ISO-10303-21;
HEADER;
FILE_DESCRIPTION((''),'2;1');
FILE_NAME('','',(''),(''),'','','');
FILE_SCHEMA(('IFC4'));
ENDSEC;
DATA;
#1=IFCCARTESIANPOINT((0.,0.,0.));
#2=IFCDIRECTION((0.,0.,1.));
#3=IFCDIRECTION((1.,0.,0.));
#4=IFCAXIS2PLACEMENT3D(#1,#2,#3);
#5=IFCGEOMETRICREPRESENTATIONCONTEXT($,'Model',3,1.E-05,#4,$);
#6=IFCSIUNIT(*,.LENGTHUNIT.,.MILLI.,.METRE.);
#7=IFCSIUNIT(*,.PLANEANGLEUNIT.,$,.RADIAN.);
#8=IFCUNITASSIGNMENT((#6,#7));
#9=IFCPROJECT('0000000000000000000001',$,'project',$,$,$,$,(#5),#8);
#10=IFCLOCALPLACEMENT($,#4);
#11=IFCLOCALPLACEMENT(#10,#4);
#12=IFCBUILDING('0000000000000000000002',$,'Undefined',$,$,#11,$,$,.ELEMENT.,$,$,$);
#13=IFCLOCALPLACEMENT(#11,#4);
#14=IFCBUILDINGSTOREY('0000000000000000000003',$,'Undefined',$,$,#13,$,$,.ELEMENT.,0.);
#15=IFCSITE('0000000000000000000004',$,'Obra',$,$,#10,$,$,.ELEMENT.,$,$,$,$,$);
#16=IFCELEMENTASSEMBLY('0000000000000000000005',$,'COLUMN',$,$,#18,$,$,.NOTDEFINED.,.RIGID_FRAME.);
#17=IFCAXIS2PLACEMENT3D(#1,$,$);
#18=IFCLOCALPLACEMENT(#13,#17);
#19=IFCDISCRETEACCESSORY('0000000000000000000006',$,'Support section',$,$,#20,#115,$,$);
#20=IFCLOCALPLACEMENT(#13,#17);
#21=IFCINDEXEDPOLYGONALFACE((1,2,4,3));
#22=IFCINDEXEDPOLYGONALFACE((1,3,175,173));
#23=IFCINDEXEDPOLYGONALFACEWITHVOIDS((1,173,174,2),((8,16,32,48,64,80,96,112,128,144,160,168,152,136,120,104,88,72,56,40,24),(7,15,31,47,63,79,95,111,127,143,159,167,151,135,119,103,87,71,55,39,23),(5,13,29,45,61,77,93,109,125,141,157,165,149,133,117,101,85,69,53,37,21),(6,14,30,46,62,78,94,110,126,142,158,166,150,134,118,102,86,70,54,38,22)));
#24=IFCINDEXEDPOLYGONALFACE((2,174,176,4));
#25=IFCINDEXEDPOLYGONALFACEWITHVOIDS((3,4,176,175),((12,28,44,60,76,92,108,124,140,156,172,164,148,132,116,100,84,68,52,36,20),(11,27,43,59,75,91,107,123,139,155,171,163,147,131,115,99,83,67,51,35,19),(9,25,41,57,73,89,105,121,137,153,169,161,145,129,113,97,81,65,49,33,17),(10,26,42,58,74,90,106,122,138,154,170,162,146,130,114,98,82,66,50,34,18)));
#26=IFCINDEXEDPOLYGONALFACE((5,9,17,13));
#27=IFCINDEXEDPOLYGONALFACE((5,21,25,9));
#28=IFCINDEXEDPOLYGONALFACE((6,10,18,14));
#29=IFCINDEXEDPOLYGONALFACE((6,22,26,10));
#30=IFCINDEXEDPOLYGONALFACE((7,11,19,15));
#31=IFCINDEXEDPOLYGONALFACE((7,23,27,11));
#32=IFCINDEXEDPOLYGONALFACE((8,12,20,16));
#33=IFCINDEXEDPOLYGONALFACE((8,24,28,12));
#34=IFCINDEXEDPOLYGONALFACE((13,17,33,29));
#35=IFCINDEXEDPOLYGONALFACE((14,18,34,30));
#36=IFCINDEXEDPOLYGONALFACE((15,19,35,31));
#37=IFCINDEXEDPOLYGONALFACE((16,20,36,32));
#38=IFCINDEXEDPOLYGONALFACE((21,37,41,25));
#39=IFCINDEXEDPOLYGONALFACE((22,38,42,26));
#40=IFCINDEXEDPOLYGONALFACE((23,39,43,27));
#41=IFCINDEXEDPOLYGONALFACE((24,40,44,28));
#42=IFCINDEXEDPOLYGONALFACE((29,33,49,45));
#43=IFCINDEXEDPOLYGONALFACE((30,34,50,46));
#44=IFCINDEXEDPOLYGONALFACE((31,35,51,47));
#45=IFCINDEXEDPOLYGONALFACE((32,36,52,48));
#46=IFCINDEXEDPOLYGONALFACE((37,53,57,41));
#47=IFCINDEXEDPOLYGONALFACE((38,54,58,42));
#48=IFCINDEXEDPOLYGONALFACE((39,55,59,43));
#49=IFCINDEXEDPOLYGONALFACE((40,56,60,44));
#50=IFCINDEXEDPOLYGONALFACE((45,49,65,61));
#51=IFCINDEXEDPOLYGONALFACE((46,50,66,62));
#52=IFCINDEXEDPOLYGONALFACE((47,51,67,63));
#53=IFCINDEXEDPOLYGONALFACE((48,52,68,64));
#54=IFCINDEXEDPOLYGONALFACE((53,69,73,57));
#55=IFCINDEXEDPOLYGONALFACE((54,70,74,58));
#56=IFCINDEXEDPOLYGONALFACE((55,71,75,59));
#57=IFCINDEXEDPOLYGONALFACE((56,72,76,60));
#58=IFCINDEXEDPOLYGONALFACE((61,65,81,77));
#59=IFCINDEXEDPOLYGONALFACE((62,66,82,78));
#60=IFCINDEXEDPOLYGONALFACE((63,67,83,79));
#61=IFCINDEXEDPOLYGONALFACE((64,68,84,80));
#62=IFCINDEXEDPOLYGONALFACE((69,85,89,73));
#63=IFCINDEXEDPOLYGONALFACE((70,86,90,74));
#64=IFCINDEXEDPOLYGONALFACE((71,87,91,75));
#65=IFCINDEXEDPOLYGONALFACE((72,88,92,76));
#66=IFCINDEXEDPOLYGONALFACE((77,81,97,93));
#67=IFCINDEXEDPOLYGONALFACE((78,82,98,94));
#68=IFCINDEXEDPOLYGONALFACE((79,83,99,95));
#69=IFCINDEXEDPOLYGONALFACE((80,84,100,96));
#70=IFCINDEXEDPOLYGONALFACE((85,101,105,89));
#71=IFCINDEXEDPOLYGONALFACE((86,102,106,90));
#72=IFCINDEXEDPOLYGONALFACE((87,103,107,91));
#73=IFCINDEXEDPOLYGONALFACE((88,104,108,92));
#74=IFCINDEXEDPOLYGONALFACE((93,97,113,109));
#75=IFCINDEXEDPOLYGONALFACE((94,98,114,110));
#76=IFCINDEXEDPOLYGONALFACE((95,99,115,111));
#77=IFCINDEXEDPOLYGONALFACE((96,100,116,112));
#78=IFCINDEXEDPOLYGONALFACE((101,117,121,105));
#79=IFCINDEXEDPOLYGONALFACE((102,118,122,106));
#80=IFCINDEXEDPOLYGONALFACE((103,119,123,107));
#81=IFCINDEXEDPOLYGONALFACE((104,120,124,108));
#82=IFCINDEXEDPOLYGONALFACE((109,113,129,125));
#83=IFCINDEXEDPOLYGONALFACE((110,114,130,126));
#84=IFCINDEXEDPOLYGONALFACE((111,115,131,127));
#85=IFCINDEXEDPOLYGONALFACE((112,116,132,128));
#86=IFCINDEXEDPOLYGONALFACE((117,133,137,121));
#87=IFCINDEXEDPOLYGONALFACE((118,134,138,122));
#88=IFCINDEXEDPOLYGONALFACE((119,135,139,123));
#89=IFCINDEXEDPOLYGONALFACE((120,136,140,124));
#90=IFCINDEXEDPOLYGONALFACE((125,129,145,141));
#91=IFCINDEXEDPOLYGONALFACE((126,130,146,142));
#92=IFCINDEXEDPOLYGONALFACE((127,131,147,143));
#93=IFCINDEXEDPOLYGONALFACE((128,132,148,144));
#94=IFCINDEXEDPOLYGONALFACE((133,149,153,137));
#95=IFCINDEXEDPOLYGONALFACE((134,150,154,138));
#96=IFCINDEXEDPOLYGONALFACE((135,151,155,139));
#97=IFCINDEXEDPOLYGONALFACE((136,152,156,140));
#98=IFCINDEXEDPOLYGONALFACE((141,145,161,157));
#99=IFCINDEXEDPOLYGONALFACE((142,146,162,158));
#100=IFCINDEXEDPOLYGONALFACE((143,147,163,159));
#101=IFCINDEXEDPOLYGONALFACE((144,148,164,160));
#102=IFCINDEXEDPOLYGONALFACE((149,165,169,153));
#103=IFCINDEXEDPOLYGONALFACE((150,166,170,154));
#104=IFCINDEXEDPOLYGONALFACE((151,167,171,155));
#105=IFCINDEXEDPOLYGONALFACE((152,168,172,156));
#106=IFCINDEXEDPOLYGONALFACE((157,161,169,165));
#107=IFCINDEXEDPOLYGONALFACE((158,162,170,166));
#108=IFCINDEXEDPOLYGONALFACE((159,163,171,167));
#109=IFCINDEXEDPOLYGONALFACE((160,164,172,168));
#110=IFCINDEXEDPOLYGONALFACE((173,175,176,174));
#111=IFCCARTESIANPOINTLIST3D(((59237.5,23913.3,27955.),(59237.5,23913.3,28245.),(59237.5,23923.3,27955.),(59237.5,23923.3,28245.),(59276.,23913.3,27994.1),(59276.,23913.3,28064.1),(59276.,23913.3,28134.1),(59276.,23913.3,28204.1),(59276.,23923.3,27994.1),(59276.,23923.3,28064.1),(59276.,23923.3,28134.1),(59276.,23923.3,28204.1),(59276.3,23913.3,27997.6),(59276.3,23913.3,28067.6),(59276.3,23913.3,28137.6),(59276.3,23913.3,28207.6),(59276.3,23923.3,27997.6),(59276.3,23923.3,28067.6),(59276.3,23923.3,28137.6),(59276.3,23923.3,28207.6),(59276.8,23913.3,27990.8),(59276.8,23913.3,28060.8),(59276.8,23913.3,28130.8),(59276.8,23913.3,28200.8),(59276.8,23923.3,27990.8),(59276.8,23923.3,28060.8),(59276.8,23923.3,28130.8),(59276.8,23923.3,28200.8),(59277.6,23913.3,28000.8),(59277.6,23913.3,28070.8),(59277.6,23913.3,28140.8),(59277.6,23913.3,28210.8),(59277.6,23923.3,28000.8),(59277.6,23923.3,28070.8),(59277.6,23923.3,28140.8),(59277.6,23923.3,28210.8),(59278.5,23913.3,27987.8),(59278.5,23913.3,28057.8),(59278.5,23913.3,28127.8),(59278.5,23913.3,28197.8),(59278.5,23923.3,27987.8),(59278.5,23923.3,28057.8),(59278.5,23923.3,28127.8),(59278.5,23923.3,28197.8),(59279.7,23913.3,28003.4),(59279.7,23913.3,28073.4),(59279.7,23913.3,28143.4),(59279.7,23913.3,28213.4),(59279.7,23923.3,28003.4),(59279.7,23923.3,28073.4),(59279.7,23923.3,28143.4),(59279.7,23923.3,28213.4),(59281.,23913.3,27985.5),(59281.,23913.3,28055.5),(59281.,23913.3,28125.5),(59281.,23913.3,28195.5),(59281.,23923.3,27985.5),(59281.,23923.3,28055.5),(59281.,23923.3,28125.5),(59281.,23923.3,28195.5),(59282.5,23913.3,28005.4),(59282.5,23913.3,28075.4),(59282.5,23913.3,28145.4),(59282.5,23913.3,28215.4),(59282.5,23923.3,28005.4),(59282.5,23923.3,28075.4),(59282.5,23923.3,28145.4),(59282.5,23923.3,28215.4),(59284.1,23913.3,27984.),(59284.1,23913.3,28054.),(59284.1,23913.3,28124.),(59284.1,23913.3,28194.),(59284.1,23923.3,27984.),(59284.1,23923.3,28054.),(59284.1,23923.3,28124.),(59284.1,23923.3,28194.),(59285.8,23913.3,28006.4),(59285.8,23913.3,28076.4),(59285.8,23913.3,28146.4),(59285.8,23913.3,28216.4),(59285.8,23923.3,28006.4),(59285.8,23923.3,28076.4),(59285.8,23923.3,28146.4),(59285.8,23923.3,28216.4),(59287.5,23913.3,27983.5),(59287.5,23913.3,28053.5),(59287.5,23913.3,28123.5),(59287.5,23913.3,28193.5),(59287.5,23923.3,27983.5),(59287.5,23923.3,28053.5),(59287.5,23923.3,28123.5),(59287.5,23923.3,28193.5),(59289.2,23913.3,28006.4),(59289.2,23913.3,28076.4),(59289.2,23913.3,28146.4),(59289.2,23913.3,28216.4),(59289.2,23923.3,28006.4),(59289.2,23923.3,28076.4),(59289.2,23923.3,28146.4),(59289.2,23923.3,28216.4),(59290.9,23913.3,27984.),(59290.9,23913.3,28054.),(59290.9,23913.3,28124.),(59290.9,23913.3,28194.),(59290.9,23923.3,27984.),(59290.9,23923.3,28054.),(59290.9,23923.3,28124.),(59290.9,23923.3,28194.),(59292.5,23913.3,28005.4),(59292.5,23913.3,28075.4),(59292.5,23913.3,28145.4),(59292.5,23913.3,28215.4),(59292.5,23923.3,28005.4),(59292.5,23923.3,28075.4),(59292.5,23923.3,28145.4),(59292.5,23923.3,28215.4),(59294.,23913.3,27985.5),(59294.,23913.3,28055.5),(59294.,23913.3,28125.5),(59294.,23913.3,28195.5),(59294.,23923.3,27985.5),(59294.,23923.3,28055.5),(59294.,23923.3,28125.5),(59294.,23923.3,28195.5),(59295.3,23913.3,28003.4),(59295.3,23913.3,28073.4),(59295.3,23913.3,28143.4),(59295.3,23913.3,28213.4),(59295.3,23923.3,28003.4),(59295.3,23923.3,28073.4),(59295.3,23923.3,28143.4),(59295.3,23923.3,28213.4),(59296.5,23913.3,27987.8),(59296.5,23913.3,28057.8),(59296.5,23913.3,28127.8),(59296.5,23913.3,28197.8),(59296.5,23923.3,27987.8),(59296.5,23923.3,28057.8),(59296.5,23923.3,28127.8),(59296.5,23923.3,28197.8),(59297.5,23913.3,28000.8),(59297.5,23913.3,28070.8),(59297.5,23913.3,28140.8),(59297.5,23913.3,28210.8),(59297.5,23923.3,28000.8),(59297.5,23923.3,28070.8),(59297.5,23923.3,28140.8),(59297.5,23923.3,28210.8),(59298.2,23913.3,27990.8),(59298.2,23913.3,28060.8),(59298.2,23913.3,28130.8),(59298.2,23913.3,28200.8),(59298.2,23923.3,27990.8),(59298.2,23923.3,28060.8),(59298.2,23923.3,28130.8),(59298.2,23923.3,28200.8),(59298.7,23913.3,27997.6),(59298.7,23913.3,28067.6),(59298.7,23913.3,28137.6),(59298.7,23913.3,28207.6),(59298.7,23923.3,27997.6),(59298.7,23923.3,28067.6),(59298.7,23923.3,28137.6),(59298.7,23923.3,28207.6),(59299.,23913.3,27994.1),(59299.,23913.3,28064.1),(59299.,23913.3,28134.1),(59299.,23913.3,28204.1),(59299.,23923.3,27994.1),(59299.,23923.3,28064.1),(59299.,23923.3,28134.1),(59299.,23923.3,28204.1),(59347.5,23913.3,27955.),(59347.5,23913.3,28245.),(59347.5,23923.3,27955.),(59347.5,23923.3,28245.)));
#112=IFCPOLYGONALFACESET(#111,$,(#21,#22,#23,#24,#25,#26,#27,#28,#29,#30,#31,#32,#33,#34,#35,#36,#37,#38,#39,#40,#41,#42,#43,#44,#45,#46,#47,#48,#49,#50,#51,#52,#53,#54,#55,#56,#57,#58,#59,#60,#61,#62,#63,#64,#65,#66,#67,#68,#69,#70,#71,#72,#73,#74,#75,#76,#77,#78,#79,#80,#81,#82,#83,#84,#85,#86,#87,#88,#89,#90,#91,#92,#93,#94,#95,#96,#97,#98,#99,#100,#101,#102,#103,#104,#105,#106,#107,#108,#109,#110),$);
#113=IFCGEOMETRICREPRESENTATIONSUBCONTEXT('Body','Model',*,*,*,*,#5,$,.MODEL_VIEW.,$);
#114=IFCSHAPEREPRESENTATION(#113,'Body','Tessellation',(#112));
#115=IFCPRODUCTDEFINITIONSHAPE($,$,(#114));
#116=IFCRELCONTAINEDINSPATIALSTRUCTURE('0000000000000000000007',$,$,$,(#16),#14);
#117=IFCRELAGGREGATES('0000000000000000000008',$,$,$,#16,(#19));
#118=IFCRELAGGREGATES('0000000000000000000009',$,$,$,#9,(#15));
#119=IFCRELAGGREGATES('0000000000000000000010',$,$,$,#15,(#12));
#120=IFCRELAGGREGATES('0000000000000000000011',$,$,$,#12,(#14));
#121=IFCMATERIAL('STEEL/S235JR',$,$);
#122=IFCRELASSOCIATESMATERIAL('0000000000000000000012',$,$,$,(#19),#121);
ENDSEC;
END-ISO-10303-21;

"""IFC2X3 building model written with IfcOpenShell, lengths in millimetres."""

from ifc_helpers import new_model, si_unit, frame, origin_with_axes, origin_2d_with_axis, place, context, subcontext, project, spatial, rectangle, circle, extrude, source, transform, mapped, material, element, aggregate, save


model = new_model("IFC2X3")

# Units and contexts
model_context = context("Model", 3, precision=1e-05, world=origin_with_axes())
body_context = subcontext(model_context, "Body", "Model", "MODEL_VIEW")
ifc_project = project(units=[si_unit("LENGTHUNIT", "METRE", prefix="MILLI"), si_unit("PLANEANGLEUNIT", "RADIAN")], contexts=[model_context])

# Site, building, storey
site_placement = place(None, origin_with_axes())
site = spatial("IfcSite", under=ifc_project, at=site_placement, Name="Obra", CompositionType="ELEMENT")
building_placement = place(site_placement, origin_with_axes())
building = spatial("IfcBuilding", under=site, at=building_placement, Name="Undefined", CompositionType="ELEMENT")
storey_placement = place(building_placement, origin_with_axes())
storey = spatial("IfcBuildingStorey", under=building, at=storey_placement, Name="Undefined", CompositionType="ELEMENT", Elevation=0.0)

# Element assembly
assembly_1_placement = place(storey_placement, origin_with_axes())
assembly_1 = element("IfcElementAssembly", 1, at=assembly_1_placement, inside=storey, Name="COLUMN", AssemblyPlace="NOTDEFINED", PredefinedType="RIGID_FRAME")
ifc_material_1 = material(Name="STEEL/S235JR")

# Discrete accessory, opening
shared_shape_1 = source(origin_with_axes(), body_context, "Body", "SweptSolid", [
    extrude(circle(Radius=11.5, at=origin_2d_with_axis()), frame((0.0, -14.4, 0.0), z_axis=(0.0, 1.0, 0.0), x_axis=(1.0, 0.0, 0.0)), (0.0, 0.0, 1.0), 10.2),
])
discrete_accessory_1_placement = place(assembly_1_placement, frame((59292.5, 23918.3, 27955.0), z_axis=(0.0, 0.0, 1.0), x_axis=(1.0, 0.0, 0.0)))
discrete_accessory_1 = element("IfcDiscreteAccessory", 2, at=discrete_accessory_1_placement, material=ifc_material_1, Name="Support section", context=body_context, shape_type="SweptSolid", body=[
    extrude(rectangle(XDim=10.0, YDim=110.0, at=origin_2d_with_axis()), frame((0.0, 0.0, 290.0), z_axis=(0.0, 0.0, -1.0), x_axis=(0.0, 1.0, 0.0)), (0.0, 0.0, 1.0), 290.0),
])
opening_1_placement = place(assembly_1_placement, frame((59337.5, 23909.0, 28300.0), z_axis=(-1.0, 0.0, 0.0), x_axis=(0.0, 0.0, -1.0)))
element("IfcOpeningElement", 3, at=opening_1_placement, cuts=discrete_accessory_1, ObjectType="Opening", context=body_context, shape_type="MappedRepresentation", body=[
    mapped(shared_shape_1, transform((95.0, 0.0, 50.0))),
    mapped(shared_shape_1, transform((165.0, 0.0, 50.0))),
    mapped(shared_shape_1, transform((235.0, 0.0, 50.0))),
    mapped(shared_shape_1, transform((305.0, 0.0, 50.0))),
])
aggregate(assembly_1, [discrete_accessory_1])

save(model, "model.ifc")
